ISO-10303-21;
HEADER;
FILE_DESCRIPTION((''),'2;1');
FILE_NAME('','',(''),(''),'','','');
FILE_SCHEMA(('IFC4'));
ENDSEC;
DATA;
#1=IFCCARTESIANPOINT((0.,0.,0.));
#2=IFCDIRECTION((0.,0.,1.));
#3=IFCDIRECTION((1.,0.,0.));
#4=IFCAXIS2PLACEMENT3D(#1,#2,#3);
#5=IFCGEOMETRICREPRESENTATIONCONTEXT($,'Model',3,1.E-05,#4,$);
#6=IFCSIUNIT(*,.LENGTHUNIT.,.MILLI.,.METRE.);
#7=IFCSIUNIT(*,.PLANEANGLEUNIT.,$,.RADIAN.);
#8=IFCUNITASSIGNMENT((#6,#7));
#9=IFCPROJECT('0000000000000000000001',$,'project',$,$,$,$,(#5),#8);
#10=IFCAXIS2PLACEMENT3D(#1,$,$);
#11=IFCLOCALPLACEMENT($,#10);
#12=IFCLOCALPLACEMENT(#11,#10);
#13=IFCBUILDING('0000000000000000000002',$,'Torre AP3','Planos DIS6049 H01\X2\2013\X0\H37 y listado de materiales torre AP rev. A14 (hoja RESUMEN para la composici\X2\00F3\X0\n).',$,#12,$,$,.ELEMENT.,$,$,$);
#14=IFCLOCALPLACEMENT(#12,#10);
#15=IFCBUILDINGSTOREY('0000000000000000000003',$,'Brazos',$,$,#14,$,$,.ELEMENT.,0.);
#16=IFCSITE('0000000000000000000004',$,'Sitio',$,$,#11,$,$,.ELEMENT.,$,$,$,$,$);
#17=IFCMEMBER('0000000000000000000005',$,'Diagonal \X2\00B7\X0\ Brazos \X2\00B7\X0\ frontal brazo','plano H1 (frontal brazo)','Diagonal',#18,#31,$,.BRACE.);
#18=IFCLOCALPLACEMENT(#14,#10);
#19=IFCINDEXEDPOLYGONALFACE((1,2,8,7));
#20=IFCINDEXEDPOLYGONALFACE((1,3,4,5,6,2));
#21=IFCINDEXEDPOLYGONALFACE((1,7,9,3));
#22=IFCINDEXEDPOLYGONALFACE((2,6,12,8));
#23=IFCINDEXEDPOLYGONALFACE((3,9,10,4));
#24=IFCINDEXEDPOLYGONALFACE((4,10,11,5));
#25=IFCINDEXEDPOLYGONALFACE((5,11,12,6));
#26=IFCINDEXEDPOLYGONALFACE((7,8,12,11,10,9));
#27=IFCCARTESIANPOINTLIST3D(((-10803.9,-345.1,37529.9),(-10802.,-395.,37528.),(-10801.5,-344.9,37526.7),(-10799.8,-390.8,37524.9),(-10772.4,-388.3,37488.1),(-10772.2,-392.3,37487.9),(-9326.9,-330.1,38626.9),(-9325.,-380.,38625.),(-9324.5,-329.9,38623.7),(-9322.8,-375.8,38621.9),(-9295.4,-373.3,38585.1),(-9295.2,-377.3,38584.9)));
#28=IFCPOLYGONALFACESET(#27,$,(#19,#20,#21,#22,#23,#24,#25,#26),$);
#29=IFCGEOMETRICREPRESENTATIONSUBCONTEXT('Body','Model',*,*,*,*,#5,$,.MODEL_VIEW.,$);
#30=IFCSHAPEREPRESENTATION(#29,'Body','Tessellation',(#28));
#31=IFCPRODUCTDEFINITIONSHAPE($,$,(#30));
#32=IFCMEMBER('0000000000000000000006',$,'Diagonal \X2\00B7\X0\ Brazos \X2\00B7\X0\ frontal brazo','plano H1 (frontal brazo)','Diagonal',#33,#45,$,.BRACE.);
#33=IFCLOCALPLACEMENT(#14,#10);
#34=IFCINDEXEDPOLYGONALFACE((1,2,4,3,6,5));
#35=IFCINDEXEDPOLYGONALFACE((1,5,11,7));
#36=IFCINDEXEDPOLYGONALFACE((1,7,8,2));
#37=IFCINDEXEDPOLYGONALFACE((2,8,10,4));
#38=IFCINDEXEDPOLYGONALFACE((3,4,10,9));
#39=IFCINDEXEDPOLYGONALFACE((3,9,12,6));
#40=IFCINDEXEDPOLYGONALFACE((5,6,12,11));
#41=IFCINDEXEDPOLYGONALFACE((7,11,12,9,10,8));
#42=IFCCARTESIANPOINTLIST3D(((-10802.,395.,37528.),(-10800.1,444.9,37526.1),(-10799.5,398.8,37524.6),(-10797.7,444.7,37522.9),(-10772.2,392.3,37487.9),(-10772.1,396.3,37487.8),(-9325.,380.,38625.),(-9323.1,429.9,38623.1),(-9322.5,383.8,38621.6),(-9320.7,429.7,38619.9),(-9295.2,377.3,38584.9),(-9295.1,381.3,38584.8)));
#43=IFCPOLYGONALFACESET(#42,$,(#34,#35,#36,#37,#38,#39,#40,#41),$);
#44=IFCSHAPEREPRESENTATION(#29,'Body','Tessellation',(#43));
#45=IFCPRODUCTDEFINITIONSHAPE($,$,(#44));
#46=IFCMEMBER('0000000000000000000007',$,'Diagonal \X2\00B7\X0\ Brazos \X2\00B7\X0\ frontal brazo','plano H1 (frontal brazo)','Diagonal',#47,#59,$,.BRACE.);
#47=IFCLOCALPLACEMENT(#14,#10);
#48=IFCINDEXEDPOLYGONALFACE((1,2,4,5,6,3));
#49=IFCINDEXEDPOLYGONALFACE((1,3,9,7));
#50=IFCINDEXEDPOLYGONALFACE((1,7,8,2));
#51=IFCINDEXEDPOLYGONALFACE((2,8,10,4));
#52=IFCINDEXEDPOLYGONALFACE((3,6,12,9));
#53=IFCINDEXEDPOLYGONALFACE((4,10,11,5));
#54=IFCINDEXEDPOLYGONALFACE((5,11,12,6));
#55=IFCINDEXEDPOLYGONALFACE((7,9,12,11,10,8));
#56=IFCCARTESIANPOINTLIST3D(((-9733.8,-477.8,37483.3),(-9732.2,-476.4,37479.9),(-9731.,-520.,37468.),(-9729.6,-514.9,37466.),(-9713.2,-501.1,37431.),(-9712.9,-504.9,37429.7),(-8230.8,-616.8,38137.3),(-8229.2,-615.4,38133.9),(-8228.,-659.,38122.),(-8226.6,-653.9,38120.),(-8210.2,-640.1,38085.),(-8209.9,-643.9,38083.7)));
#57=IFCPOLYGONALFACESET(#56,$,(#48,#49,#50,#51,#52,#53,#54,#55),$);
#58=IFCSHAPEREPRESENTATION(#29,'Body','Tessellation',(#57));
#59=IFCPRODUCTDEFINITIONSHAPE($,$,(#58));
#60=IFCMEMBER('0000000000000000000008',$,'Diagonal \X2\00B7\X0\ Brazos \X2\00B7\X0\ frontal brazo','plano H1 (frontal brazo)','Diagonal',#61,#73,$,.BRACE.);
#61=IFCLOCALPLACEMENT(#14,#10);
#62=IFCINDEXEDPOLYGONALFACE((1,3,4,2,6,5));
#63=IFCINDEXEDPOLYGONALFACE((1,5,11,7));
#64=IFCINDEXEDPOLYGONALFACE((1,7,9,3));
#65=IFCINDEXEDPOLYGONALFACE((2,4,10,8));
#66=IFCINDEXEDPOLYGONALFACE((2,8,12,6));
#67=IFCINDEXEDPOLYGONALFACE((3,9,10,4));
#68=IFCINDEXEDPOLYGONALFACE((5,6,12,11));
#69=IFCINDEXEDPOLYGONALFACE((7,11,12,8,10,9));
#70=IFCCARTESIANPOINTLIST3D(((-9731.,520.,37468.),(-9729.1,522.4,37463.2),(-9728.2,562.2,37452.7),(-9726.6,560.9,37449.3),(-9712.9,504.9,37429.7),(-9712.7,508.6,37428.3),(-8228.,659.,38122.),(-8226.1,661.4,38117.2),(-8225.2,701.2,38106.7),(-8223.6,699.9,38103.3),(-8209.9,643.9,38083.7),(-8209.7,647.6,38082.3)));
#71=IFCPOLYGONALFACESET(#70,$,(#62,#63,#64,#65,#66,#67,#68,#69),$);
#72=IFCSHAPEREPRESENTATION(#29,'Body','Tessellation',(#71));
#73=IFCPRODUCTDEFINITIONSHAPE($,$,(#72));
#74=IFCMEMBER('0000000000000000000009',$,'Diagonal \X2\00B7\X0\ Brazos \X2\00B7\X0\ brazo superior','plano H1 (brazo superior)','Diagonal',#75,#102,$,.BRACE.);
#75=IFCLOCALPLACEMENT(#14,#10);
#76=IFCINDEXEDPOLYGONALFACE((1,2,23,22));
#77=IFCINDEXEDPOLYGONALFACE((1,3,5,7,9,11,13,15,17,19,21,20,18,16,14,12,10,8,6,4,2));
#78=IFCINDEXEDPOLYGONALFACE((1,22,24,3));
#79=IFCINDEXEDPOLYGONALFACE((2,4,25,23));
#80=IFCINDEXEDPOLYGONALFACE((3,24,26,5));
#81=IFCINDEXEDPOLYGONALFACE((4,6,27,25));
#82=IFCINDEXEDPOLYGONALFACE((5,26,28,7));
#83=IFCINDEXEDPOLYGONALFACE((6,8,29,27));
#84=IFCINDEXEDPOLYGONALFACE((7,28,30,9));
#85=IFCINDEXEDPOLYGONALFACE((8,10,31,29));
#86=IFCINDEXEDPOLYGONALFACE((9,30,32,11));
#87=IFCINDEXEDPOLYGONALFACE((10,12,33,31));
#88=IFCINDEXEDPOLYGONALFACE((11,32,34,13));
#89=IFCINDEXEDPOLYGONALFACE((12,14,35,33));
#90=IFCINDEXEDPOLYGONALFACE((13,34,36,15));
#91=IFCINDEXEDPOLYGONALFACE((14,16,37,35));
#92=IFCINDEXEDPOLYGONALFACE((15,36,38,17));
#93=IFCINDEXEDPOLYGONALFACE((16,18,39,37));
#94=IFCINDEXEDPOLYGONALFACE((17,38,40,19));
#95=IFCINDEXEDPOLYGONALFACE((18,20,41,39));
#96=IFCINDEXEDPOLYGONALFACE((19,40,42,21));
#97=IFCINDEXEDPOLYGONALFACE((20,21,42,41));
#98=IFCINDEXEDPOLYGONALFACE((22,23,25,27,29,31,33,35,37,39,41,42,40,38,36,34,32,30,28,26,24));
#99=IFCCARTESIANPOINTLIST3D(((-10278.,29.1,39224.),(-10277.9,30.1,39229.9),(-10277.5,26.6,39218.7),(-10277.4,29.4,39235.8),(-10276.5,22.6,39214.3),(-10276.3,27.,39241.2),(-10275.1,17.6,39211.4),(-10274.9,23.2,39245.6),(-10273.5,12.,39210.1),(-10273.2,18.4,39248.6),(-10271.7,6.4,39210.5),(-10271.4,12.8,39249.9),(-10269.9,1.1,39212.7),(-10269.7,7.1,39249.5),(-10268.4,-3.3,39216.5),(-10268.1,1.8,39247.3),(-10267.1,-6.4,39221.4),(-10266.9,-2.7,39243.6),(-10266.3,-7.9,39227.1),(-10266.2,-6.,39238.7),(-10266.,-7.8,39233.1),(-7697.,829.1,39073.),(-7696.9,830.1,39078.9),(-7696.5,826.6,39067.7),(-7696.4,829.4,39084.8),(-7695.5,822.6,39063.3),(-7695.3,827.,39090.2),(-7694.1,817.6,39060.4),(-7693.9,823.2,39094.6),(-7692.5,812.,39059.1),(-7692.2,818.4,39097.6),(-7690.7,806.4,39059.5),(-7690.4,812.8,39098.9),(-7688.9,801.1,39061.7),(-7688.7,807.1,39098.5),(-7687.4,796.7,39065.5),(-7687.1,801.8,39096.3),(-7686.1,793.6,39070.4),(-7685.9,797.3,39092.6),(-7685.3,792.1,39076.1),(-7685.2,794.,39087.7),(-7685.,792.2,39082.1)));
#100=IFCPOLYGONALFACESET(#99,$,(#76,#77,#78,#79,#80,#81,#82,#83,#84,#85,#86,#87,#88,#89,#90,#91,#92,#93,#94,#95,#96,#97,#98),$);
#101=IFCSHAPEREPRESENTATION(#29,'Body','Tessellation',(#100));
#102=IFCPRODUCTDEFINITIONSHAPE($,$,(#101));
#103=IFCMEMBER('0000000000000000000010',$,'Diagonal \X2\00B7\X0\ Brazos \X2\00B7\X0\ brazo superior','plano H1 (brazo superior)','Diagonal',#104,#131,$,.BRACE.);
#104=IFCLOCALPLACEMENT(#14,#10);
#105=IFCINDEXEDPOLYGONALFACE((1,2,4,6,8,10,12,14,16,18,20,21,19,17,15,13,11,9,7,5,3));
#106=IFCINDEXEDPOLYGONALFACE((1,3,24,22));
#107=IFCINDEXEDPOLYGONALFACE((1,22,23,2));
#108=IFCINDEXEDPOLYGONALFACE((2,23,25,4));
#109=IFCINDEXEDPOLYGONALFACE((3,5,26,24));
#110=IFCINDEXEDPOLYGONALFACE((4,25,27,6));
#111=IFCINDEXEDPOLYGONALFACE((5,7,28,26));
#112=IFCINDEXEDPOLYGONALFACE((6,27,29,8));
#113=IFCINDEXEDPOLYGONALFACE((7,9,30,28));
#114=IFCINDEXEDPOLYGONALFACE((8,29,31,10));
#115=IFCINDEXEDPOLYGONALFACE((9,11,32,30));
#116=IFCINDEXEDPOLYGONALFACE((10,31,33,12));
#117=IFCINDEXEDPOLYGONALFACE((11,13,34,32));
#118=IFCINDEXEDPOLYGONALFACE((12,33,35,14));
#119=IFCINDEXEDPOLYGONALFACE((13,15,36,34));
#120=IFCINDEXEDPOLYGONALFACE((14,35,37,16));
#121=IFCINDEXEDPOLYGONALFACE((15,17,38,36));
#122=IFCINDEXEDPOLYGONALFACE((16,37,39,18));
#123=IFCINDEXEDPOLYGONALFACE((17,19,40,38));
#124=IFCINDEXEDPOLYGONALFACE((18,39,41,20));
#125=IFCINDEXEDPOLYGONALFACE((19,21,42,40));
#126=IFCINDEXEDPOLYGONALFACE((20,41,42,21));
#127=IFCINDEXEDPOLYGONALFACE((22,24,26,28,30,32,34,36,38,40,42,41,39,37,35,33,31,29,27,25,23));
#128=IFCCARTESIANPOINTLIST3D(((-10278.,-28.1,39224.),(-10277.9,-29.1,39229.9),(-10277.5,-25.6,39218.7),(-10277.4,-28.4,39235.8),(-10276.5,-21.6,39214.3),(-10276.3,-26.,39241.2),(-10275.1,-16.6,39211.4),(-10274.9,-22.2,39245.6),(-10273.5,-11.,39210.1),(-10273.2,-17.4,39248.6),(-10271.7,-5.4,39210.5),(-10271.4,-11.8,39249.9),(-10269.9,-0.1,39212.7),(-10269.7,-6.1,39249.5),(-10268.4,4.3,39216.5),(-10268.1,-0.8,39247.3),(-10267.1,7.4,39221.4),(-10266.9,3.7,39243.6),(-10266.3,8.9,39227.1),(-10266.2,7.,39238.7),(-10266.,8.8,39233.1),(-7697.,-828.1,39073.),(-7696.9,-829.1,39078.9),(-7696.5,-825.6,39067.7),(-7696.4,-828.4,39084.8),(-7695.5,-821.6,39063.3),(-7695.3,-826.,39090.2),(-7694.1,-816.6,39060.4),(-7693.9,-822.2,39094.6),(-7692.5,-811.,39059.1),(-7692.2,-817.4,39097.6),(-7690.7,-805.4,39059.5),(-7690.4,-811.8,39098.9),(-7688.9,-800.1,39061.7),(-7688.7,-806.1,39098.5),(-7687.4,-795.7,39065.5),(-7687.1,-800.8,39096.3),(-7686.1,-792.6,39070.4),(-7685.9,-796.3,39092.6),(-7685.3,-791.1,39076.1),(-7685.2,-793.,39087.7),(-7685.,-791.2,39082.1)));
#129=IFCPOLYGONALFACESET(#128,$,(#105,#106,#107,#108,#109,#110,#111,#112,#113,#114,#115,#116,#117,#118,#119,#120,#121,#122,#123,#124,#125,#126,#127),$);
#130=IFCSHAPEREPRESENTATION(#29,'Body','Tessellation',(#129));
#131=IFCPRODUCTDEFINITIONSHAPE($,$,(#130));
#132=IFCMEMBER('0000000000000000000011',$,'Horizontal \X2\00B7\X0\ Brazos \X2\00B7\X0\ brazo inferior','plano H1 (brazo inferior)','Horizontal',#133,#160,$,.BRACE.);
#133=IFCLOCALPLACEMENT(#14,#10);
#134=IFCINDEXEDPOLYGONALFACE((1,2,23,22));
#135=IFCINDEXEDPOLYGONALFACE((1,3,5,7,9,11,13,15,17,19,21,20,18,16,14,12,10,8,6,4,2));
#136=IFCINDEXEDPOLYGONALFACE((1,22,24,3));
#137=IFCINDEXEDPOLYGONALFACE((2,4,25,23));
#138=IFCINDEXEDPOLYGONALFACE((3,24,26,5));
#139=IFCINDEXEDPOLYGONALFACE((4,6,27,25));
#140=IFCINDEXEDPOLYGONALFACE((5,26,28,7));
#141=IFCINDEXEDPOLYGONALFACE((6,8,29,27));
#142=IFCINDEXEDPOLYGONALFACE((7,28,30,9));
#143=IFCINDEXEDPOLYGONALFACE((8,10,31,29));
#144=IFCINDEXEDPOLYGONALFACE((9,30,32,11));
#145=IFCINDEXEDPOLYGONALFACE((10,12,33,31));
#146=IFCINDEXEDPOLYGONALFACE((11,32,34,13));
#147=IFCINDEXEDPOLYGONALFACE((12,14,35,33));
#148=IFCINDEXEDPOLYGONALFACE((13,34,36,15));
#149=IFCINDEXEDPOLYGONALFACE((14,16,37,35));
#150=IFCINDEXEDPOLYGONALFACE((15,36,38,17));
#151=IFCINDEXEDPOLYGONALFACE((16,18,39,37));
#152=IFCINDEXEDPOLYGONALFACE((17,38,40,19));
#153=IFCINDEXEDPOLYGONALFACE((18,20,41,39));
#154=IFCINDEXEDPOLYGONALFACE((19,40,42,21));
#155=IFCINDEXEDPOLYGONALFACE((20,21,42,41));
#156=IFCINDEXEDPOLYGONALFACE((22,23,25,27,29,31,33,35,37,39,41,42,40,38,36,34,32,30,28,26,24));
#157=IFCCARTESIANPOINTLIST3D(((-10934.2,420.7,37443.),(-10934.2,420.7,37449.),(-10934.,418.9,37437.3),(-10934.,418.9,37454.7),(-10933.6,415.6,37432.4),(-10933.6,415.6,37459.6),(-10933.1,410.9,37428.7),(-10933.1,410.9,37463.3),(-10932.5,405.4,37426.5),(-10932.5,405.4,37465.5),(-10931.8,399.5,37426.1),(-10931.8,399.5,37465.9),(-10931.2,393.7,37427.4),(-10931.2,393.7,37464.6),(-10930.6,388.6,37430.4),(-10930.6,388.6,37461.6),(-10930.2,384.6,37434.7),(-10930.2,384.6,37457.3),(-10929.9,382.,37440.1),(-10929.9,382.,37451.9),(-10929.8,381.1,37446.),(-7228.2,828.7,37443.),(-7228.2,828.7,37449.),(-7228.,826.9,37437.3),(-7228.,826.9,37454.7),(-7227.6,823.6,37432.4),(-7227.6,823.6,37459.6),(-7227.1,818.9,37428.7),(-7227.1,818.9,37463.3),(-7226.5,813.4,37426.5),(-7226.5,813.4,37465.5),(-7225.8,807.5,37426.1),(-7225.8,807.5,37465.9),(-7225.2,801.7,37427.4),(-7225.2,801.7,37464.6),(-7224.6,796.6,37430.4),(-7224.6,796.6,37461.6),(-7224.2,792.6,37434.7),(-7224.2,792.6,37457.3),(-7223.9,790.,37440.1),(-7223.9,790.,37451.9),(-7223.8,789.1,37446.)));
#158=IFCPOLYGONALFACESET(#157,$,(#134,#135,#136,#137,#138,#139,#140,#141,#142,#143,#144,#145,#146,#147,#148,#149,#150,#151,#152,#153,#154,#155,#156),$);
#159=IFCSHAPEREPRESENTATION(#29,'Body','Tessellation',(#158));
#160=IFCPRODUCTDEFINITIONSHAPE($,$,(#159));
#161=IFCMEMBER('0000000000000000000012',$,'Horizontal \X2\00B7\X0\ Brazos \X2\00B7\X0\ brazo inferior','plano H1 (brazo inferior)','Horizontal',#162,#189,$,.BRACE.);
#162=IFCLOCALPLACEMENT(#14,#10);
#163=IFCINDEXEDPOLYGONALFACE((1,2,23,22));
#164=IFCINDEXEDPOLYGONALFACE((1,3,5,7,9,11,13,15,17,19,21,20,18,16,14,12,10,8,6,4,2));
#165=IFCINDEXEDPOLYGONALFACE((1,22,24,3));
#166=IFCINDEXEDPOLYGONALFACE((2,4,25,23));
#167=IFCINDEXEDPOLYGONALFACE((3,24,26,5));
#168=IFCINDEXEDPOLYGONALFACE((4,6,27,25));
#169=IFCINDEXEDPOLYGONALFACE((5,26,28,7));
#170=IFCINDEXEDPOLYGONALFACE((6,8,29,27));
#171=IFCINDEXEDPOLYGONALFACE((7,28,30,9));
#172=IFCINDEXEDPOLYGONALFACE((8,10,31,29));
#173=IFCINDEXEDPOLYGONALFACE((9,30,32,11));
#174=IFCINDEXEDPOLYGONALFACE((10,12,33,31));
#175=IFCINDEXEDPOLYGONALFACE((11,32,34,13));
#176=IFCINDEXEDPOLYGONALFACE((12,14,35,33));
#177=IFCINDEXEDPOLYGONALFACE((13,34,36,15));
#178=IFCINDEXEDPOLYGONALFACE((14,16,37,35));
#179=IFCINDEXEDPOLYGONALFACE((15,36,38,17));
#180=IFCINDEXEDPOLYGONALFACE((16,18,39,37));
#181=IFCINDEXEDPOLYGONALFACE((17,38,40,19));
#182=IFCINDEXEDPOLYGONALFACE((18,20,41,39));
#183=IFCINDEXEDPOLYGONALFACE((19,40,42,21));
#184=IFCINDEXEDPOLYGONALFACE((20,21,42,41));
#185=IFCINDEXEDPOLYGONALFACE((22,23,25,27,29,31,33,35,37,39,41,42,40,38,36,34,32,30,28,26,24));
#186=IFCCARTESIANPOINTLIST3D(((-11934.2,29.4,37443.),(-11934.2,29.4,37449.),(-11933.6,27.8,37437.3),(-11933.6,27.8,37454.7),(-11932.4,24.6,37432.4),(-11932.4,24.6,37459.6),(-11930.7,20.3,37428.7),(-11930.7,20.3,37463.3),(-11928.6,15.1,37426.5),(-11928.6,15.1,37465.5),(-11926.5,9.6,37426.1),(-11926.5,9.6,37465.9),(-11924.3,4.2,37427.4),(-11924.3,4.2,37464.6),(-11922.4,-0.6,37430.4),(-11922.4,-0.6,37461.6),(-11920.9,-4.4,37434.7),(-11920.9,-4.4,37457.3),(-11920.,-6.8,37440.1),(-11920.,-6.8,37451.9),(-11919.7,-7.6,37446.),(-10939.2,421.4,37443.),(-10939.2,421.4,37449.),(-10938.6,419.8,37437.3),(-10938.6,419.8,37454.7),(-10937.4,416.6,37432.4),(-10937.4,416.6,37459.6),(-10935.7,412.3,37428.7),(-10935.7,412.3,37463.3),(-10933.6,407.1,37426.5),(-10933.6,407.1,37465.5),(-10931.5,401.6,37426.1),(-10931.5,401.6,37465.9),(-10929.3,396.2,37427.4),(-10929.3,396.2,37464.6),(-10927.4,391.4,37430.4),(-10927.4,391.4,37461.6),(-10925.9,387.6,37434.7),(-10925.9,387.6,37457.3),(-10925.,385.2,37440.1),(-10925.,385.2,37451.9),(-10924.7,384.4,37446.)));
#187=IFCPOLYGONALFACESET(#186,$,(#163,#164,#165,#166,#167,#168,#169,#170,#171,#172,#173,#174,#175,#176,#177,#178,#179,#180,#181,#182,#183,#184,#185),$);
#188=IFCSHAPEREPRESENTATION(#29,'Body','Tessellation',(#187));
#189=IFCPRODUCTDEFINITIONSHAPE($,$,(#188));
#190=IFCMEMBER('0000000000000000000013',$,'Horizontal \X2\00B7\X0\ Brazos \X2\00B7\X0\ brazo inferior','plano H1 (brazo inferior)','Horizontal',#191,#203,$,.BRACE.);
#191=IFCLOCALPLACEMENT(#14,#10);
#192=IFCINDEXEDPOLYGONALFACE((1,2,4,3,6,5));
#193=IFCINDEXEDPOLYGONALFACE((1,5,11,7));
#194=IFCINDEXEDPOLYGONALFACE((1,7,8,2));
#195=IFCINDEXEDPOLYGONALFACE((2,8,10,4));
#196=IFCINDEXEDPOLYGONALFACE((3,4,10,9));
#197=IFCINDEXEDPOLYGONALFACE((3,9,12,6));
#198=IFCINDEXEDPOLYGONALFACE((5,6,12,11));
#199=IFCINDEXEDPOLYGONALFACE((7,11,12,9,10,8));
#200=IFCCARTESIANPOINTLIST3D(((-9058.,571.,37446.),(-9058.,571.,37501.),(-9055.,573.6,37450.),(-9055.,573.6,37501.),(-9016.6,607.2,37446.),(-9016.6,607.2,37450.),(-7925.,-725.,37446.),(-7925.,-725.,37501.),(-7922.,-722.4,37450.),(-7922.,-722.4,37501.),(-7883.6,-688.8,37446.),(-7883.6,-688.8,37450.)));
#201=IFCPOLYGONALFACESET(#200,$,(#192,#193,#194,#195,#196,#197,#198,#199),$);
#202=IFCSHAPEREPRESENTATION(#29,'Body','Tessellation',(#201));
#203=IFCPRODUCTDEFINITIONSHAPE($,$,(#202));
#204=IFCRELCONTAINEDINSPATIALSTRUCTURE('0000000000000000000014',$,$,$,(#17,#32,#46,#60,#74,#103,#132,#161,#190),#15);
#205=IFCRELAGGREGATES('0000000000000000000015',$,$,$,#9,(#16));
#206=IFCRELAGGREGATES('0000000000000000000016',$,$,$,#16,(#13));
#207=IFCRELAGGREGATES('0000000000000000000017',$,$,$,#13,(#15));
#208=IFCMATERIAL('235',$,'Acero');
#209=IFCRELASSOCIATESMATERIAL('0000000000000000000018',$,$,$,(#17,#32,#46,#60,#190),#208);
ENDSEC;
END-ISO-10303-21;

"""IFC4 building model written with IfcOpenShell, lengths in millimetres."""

from ifc_helpers import new_model, si_unit, frame, frame_2d, origin, origin_with_axes, place, context, subcontext, project, spatial, circle, l_section, extrude, material, element, save


model = new_model("IFC4")

# Units and contexts
model_context = context("Model", 3, precision=1e-05, world=origin_with_axes())
body_context = subcontext(model_context, "Body", "Model", "MODEL_VIEW")
ifc_project = project(units=[si_unit("LENGTHUNIT", "METRE", prefix="MILLI"), si_unit("PLANEANGLEUNIT", "RADIAN")], contexts=[model_context])

# Site, building, storey
site_placement = place(None, origin())
site = spatial("IfcSite", under=ifc_project, at=site_placement, Name="Sitio", CompositionType="ELEMENT")
building_placement = place(site_placement, origin())
building = spatial("IfcBuilding", under=site, at=building_placement, Name="Torre AP3", Description="Planos DIS6049 H01–H37 y listado de materiales torre AP rev. A14 (hoja RESUMEN para la composición).", CompositionType="ELEMENT")
storey_placement = place(building_placement, origin())
storey = spatial("IfcBuildingStorey", under=building, at=storey_placement, Name="Brazos", CompositionType="ELEMENT", Elevation=0.0)

# Members
ifc_material_1 = material(Name="235", Category="Acero")
for number, where, z_axis, x_axis, name in (
    (1, (-10802.0, -395.0, 37528.0), (0.802769, 0.008153, 0.596234), (0.595049, 0.053521, -0.801905), "Diagonal · Brazos · frontal brazo"),
    (2, (-10802.0, 395.0, 37528.0), (0.802769, -0.008153, 0.596234), (0.595049, -0.053521, -0.801905), "Diagonal · Brazos · frontal brazo"),
):
    element("IfcMember", number, at=place(storey_placement, frame(where, z_axis=z_axis, x_axis=x_axis)), inside=storey, material=ifc_material_1, Name=name, Description="plano H1 (frontal brazo)", ObjectType="Diagonal", PredefinedType="BRACE", context=body_context, shape_type="SweptSolid", body=[
        extrude(l_section(Depth=50.0, Width=50.0, Thickness=4.0, at=frame_2d((25.0, 25.0))), None, (0.0, 0.0, 1.0), 1839.9),
    ])
for number, where, z_axis, x_axis, name in (
    (3, (-9731.0, -520.0, 37468.0), (0.913674, -0.084498, 0.397567), (0.401755, 0.335963, -0.851893), "Diagonal · Brazos · frontal brazo"),
    (4, (-9731.0, 520.0, 37468.0), (0.913674, 0.084498, 0.397567), (0.401755, -0.335963, -0.851893), "Diagonal · Brazos · frontal brazo"),
):
    element("IfcMember", number, at=place(storey_placement, frame(where, z_axis=z_axis, x_axis=x_axis)), inside=storey, material=ifc_material_1, Name=name, Description="plano H1 (frontal brazo)", ObjectType="Diagonal", PredefinedType="BRACE", context=body_context, shape_type="SweptSolid", body=[
        extrude(l_section(Depth=45.0, Width=45.0, Thickness=4.0, at=frame_2d((22.5, 22.5))), None, (0.0, 0.0, 1.0), 1645.0),
    ])
for number, where, z_axis, x_axis, name in (
    (5, (-7691.0, 811.0, 39079.0), (-0.953681, -0.2956, 0.055795), (0.300728, -0.941427, 0.152572), "Diagonal · Brazos · brazo superior"),
    (6, (-10272.0, -10.0, 39230.0), (0.953681, -0.2956, -0.055795), (0.300729, 0.941418, 0.152624), "Diagonal · Brazos · brazo superior"),
):
    element("IfcMember", number, at=place(storey_placement, frame(where, z_axis=z_axis, x_axis=x_axis)), inside=storey, Name=name, Description="plano H1 (brazo superior)", ObjectType="Diagonal", PredefinedType="BRACE", context=body_context, shape_type="SweptSolid", body=[
        extrude(circle(Radius=20.0), None, (0.0, 0.0, 1.0), 2706.4),
    ])
member_1_placement = place(storey_placement, frame((-7226.0, 809.0, 37446.0), z_axis=(-0.993994, -0.109431, 0.0), x_axis=(0.109431, -0.993994, 0.0)))
element("IfcMember", 7, at=member_1_placement, inside=storey, Name="Horizontal · Brazos · brazo inferior", Description="plano H1 (brazo inferior)", ObjectType="Horizontal", PredefinedType="BRACE", context=body_context, shape_type="SweptSolid", body=[
    extrude(circle(Radius=20.0), None, (0.0, 0.0, 1.0), 3728.4),
])
member_2_placement = place(storey_placement, frame((-10932.0, 403.0, 37446.0), z_axis=(-0.930399, -0.366549, 0.0), x_axis=(0.366549, -0.930399, 0.0)))
element("IfcMember", 8, at=member_2_placement, inside=storey, Name="Horizontal · Brazos · brazo inferior", Description="plano H1 (brazo inferior)", ObjectType="Horizontal", PredefinedType="BRACE", context=body_context, shape_type="SweptSolid", body=[
    extrude(circle(Radius=20.0), None, (0.0, 0.0, 1.0), 1069.4),
])
member_3_placement = place(storey_placement, frame((-9058.0, 571.0, 37446.0), z_axis=(0.658176, -0.752865, 0.0), x_axis=(0.752865, 0.658176, 0.0)))
element("IfcMember", 9, at=member_3_placement, inside=storey, material=ifc_material_1, Name="Horizontal · Brazos · brazo inferior", Description="plano H1 (brazo inferior)", ObjectType="Horizontal", PredefinedType="BRACE", context=body_context, shape_type="SweptSolid", body=[
    extrude(l_section(Depth=55.0, Width=55.0, Thickness=4.0, at=frame_2d((27.5, 27.5))), None, (0.0, 0.0, 1.0), 1721.4),
])

save(model, "model.ifc")
